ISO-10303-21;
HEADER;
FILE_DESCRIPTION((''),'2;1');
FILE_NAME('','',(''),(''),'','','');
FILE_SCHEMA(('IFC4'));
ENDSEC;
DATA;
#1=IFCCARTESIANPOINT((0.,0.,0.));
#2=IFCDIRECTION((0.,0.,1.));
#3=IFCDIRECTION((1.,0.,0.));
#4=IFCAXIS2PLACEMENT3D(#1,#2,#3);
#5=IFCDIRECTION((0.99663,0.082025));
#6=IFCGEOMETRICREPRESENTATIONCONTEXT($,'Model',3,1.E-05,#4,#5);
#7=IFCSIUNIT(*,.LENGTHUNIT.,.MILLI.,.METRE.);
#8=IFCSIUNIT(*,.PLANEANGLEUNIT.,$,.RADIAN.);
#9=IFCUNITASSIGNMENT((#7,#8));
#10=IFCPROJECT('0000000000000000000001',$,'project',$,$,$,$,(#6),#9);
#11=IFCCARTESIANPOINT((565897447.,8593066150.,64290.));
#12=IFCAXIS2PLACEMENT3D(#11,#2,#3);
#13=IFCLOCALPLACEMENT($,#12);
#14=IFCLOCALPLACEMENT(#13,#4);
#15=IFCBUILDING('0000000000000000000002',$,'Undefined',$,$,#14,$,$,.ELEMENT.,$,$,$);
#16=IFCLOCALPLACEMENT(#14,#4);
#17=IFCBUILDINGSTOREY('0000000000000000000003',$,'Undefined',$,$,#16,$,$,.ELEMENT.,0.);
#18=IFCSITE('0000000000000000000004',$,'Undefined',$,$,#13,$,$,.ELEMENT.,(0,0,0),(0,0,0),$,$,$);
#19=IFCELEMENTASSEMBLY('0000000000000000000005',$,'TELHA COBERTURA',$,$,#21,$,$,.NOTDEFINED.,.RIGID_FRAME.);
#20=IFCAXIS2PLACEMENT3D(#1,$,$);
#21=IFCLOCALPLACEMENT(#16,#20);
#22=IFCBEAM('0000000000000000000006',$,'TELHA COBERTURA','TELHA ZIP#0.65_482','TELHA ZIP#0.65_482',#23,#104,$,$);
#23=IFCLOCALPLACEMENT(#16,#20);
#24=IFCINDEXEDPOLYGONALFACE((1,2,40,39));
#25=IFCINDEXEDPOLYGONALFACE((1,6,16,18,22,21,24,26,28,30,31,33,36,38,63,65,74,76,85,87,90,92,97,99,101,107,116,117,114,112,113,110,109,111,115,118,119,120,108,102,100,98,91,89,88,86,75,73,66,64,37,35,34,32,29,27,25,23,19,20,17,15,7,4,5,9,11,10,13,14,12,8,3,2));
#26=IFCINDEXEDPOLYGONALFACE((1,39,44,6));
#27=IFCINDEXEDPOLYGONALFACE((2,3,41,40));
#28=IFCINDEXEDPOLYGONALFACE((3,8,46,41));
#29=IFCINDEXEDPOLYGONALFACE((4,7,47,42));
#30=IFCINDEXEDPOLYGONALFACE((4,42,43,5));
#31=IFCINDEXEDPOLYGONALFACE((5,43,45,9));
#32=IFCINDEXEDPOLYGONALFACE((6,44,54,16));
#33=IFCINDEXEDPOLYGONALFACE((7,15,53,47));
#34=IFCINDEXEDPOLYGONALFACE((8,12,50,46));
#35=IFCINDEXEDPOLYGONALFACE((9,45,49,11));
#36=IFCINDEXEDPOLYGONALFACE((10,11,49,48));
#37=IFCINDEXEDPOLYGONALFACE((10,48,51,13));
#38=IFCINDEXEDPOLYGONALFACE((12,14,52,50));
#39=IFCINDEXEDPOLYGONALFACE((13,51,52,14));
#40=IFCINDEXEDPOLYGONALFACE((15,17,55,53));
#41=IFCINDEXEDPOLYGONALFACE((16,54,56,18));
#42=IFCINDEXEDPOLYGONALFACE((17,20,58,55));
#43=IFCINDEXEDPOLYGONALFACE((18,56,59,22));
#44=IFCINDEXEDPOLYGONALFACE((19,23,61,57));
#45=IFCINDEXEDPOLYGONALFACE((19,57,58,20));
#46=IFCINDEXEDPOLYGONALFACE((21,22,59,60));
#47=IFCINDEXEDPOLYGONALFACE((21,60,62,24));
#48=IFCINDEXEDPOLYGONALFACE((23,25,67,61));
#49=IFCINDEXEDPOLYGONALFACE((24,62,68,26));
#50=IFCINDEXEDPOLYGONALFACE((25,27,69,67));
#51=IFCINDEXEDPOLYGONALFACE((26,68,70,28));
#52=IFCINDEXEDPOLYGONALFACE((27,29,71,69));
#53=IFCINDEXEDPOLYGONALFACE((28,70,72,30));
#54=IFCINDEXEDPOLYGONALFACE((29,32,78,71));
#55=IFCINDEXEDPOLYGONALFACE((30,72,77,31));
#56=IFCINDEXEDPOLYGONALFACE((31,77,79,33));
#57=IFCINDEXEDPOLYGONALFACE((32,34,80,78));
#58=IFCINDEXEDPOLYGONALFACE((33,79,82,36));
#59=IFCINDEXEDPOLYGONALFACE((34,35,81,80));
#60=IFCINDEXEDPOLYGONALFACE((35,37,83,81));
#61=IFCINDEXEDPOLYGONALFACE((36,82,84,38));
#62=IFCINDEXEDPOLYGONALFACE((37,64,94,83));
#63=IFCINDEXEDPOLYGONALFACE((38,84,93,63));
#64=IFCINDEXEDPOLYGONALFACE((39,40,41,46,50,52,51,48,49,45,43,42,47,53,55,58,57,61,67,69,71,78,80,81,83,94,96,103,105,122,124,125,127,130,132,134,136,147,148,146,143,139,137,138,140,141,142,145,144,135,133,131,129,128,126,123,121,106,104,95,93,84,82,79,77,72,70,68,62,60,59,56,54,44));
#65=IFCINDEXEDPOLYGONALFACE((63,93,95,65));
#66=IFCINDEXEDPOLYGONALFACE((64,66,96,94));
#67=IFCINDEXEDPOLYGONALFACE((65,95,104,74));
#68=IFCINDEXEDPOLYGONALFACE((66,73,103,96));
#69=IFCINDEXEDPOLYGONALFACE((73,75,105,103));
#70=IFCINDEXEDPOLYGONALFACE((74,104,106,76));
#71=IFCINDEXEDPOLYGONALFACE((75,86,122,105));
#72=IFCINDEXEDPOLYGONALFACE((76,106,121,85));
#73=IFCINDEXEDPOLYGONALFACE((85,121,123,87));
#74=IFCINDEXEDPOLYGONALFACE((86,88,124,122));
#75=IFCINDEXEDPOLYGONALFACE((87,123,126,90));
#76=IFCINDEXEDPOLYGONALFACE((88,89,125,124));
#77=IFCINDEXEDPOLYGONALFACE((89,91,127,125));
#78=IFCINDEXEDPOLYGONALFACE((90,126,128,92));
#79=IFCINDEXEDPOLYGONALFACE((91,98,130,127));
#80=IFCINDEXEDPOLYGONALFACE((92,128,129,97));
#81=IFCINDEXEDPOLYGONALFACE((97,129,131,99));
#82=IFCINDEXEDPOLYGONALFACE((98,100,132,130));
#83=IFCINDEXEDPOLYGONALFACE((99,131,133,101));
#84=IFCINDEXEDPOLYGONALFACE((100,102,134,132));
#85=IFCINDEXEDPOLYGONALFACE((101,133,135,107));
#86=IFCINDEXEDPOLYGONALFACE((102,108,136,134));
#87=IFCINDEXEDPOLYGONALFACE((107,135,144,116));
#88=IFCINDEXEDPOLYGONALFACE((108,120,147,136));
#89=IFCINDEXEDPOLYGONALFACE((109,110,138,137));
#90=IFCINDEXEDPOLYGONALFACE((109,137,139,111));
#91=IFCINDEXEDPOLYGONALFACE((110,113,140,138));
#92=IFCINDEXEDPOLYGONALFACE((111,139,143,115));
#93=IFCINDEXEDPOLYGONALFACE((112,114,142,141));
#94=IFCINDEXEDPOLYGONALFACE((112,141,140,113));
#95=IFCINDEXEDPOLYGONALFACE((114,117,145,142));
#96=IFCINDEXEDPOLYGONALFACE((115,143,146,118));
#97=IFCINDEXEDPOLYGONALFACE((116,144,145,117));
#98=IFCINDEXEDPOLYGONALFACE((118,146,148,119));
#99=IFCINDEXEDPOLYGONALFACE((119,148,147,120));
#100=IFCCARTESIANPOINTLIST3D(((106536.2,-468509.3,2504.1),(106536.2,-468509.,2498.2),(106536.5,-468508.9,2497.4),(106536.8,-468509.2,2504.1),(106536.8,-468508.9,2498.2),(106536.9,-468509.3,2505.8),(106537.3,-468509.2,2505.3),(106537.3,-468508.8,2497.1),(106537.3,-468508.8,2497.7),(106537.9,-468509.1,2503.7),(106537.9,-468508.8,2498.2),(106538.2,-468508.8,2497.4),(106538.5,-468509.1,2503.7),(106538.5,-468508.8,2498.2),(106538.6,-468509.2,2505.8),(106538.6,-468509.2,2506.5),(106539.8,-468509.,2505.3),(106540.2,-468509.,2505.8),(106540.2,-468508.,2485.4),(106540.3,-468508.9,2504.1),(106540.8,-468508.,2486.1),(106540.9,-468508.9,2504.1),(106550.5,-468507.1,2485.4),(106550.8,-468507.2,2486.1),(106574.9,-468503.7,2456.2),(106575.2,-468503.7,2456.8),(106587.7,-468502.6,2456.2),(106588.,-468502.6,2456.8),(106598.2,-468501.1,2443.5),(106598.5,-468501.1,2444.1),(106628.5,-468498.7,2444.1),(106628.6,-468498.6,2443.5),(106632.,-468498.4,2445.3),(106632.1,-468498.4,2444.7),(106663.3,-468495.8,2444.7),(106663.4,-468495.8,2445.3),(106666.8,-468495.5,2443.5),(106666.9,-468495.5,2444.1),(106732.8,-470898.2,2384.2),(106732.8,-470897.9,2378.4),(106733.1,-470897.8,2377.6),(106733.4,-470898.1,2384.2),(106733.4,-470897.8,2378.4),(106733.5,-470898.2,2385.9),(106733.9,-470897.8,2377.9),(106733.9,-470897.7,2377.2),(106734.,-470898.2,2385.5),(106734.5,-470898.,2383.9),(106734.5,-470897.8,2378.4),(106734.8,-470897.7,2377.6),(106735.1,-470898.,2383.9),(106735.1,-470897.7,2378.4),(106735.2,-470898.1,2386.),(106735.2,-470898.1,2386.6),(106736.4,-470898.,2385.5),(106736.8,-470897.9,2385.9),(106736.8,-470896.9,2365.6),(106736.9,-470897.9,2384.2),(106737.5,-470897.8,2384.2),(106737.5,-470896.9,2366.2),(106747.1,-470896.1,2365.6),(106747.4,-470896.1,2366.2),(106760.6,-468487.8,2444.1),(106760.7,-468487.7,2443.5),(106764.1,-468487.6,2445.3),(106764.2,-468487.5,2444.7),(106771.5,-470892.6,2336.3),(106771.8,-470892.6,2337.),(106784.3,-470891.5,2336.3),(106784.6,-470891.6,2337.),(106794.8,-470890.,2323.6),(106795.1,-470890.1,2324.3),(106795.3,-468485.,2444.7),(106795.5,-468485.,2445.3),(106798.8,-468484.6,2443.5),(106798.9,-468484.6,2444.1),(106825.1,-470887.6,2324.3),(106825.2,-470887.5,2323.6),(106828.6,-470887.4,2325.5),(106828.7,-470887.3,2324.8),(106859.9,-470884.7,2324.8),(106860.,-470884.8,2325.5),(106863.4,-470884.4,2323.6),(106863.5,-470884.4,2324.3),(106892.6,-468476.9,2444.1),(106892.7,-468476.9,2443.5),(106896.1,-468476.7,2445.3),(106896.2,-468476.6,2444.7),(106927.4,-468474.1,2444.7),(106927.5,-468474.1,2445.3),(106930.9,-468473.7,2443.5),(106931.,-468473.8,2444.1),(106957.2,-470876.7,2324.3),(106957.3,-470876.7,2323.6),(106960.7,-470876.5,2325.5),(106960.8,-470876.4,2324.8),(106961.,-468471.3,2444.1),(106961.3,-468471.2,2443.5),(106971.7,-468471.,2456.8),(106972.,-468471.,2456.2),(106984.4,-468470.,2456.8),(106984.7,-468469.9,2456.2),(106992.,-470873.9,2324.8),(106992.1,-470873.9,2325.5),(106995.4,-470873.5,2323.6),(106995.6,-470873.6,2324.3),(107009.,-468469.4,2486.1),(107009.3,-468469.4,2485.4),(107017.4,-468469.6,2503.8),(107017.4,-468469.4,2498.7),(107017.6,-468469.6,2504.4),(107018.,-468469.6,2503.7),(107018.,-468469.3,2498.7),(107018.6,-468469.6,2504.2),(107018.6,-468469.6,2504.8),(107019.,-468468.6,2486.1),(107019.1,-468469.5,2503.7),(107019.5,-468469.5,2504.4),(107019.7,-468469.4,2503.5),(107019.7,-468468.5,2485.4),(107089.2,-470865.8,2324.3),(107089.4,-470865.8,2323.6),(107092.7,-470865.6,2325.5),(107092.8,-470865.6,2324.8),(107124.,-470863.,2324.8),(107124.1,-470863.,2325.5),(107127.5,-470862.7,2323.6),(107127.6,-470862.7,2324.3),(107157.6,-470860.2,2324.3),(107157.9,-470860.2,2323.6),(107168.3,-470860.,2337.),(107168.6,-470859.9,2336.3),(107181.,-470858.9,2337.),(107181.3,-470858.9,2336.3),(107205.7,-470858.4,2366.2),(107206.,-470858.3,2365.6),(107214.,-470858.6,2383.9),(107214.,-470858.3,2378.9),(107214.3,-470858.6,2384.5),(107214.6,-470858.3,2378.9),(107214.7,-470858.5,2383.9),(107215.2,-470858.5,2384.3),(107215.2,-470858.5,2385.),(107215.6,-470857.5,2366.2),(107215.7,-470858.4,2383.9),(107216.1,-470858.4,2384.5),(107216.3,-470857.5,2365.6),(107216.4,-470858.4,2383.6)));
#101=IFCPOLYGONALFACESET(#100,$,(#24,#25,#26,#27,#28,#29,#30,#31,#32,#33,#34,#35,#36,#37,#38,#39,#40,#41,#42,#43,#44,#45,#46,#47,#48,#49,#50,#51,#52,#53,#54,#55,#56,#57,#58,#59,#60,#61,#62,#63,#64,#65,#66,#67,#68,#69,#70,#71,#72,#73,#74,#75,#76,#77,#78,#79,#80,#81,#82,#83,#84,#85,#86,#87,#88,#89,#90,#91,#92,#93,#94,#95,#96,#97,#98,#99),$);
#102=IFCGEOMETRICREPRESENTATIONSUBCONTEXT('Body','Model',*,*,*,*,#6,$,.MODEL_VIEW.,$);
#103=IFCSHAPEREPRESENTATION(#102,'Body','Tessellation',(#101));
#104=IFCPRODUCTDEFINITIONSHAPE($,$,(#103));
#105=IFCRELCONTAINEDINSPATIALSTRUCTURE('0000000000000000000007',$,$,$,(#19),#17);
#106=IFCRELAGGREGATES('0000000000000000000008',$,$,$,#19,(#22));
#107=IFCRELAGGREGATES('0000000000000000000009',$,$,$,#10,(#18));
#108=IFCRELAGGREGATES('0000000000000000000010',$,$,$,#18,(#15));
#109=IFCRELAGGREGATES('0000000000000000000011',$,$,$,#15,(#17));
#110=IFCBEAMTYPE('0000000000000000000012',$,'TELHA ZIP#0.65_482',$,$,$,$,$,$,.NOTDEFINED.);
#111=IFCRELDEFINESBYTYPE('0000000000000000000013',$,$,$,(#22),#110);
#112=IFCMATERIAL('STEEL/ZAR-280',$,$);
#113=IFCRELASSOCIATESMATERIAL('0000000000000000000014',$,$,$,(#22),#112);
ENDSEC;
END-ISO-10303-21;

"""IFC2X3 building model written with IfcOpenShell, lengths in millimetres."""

from ifc_helpers import new_model, si_unit, direction, frame, origin_with_axes, place, context, subcontext, project, spatial, polyline, outline, extrude, material, type_object, element, aggregate, save


model = new_model("IFC2X3")

# Units and contexts
model_context = context("Model", 3, precision=1e-05, world=origin_with_axes(), true_north=direction((0.99663, 0.082025)))
body_context = subcontext(model_context, "Body", "Model", "MODEL_VIEW")
ifc_project = project(units=[si_unit("LENGTHUNIT", "METRE", prefix="MILLI"), si_unit("PLANEANGLEUNIT", "RADIAN")], contexts=[model_context])

# Site, building, storey
site_placement = place(None, frame((565897447.0, 8593066150.0, 64290.0), z_axis=(0.0, 0.0, 1.0), x_axis=(1.0, 0.0, 0.0)))
site = spatial("IfcSite", under=ifc_project, at=site_placement, Name="Undefined", CompositionType="ELEMENT", RefLatitude=(0, 0, 0), RefLongitude=(0, 0, 0))
building_placement = place(site_placement, origin_with_axes())
building = spatial("IfcBuilding", under=site, at=building_placement, Name="Undefined", CompositionType="ELEMENT")
storey_placement = place(building_placement, origin_with_axes())
storey = spatial("IfcBuildingStorey", under=building, at=storey_placement, Name="Undefined", CompositionType="ELEMENT", Elevation=0.0)

# Element assembly, beam
assembly_1_placement = place(storey_placement, origin_with_axes())
assembly_1 = element("IfcElementAssembly", 1, at=assembly_1_placement, inside=storey, Name="TELHA COBERTURA", AssemblyPlace="NOTDEFINED", PredefinedType="RIGID_FRAME")
ifc_material_1 = material(Name="STEEL/ZAR-280")
beam_type_1 = type_object("IfcBeamType", Name="TELHA ZIP#0.65_482", PredefinedType="NOTDEFINED")
beam_1_placement = place(assembly_1_placement, frame((106974.5, -470876.8, 2354.8), z_axis=(0.004096, -0.049769, 0.998752), x_axis=(-0.081923, 0.995387, 0.049938)))
beam_1 = element("IfcBeam", 2, at=beam_1_placement, type_object=beam_type_1, material=ifc_material_1, Name="TELHA COBERTURA", Description="TELHA ZIP#0.65_482", ObjectType="TELHA ZIP#0.65_482", context=body_context, shape_type="SweptSolid", body=[
    extrude(outline(polyline([(240.5, 29.7), (241.4, 30.2), (242.4, 29.7), (242.6, 28.9), (242.6, 10.8), (232.2, 10.8), (207.6, -18.5), (194.9, -18.5), (184.2, -31.2), (153.7, -31.2), (150.2, -30.0), (118.9, -30.0), (115.4, -31.2), (21.2, -31.2), (17.7, -30.0), (-13.6, -30.0), (-17.1, -31.2), (-111.3, -31.2), (-114.8, -30.0), (-146.1, -30.0), (-149.6, -31.2), (-180.1, -31.2), (-190.8, -18.5), (-203.6, -18.5), (-228.1, 10.8), (-238.5, 10.8), (-238.5, 29.5), (-239.0, 30.7), (-240.2, 31.2), (-241.4, 30.7), (-241.9, 29.5), (-241.9, 23.6), (-241.4, 23.1), (-240.9, 23.6), (-240.9, 29.1), (-240.2, 29.1), (-240.2, 23.6), (-240.6, 22.8), (-241.4, 22.4), (-242.3, 22.8), (-242.6, 23.6), (-242.6, 29.5), (-241.9, 31.2), (-240.2, 31.9), (-238.5, 31.2), (-237.9, 29.5), (-237.9, 11.4), (-227.8, 11.4), (-203.2, -17.9), (-190.4, -17.9), (-179.8, -30.5), (-149.7, -30.5), (-146.2, -29.4), (-114.7, -29.4), (-111.2, -30.5), (-17.2, -30.5), (-13.7, -29.4), (17.8, -29.4), (21.3, -30.5), (115.3, -30.5), (118.8, -29.4), (150.3, -29.4), (153.8, -30.5), (183.9, -30.5), (194.6, -17.9), (207.4, -17.9), (231.9, 11.4), (241.9, 11.4), (241.9, 29.1), (241.4, 29.5), (240.9, 29.1), (240.9, 24.1), (240.2, 24.1), (240.2, 29.2), (240.5, 29.7)])), frame((2400.0, 0.0, 0.0), z_axis=(-1.0, 0.0, 0.0), x_axis=(0.0, -1.0, 0.0)), (0.0, 0.0, 1.0), 2400.0),
])
aggregate(assembly_1, [beam_1])

save(model, "model.ifc")
